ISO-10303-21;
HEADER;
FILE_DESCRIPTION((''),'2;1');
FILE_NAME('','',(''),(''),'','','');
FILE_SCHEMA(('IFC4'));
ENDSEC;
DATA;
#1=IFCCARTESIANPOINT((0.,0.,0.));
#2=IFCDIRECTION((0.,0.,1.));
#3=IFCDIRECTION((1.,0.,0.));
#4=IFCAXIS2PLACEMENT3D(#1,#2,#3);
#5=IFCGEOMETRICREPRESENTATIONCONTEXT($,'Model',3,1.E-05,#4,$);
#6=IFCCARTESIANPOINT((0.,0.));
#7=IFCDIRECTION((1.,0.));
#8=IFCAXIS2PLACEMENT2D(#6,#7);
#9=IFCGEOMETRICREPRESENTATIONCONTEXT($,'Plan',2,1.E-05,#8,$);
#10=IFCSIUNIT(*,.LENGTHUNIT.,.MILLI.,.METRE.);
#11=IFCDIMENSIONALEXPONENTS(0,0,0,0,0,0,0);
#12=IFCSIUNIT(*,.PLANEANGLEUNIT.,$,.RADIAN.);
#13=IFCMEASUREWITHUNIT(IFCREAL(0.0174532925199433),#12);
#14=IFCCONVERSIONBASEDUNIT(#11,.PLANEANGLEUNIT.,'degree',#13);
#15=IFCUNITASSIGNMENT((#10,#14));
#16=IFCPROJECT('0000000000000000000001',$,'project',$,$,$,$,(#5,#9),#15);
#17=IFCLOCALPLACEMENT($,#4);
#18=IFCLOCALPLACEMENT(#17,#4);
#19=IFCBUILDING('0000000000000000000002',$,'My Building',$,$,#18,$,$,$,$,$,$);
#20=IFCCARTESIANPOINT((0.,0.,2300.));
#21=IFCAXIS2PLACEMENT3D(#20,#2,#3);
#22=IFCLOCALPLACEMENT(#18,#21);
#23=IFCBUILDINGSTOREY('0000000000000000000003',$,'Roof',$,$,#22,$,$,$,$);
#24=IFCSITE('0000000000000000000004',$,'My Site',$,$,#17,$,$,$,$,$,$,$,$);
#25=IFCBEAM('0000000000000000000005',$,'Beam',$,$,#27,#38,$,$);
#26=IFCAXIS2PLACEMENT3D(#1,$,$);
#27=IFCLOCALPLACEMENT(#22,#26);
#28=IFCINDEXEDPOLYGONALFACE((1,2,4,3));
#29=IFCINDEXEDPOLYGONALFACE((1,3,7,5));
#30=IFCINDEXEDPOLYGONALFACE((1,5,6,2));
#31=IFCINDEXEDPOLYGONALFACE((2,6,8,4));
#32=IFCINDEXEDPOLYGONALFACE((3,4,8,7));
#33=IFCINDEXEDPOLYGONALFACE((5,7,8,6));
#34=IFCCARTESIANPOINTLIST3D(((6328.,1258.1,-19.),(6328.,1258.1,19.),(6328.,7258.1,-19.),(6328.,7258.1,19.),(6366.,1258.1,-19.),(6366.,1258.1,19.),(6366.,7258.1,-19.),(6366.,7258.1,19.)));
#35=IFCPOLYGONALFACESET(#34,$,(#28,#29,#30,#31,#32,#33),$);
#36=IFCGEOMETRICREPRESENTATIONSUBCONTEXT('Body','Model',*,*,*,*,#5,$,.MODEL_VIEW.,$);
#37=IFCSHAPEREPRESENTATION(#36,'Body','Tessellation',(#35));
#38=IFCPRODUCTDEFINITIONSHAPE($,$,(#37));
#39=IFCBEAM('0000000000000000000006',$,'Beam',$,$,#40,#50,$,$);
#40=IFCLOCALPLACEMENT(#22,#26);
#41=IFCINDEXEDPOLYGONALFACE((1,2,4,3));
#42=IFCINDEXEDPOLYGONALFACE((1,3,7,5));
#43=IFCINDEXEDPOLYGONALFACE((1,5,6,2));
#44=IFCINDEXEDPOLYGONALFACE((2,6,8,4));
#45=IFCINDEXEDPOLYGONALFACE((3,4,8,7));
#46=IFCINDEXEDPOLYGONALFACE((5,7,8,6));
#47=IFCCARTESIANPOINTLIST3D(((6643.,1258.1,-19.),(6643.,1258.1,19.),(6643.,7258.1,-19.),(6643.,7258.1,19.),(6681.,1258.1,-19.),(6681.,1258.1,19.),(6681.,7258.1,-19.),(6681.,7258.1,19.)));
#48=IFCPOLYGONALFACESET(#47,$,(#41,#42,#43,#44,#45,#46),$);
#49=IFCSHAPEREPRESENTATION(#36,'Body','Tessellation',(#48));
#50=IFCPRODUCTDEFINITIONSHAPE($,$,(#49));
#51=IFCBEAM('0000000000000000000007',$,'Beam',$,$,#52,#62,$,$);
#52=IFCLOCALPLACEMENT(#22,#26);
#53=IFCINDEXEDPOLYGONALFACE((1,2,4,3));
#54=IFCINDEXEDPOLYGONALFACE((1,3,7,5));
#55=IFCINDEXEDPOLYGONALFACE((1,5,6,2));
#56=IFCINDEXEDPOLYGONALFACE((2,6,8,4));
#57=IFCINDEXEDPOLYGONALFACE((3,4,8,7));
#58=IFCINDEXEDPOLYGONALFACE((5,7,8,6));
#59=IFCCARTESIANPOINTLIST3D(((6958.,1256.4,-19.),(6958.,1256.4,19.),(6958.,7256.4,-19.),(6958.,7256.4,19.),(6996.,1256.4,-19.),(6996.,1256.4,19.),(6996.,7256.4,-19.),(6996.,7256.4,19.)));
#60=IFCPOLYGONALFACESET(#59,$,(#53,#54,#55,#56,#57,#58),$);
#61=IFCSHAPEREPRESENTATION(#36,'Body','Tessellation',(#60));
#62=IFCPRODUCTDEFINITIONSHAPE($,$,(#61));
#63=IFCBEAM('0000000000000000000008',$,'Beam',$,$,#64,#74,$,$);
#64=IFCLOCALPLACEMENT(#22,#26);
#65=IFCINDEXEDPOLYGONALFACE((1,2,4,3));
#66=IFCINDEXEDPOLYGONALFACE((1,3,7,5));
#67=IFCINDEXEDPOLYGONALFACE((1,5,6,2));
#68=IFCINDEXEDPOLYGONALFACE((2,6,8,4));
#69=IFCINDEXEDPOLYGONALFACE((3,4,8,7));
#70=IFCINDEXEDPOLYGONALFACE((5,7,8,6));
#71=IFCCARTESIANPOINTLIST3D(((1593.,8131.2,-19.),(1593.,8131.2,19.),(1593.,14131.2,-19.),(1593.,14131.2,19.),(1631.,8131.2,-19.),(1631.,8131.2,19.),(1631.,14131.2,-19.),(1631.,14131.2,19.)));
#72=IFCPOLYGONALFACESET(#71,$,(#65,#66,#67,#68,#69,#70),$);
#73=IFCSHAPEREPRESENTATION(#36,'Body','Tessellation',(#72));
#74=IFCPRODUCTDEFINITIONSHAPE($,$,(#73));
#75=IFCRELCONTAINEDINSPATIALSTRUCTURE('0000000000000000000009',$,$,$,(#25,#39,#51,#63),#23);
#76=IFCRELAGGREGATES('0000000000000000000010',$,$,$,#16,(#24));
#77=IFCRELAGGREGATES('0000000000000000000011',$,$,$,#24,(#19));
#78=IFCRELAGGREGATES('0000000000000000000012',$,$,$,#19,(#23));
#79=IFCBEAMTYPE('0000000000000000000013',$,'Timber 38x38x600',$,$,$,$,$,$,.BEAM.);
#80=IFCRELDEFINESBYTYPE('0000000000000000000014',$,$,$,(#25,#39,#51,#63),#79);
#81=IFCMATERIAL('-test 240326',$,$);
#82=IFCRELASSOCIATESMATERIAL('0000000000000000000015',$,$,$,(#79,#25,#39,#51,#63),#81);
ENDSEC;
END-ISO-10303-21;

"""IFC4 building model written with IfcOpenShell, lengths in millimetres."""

from ifc_helpers import new_model, entity, si_unit, converted_unit, frame, origin_with_axes, origin_2d_with_axis, place, context, subcontext, project, spatial, rectangle, extrude, material, material_profile, profile_set, profile_usage, type_object, element, save


model = new_model("IFC4")

# Units and contexts
model_context = context("Model", 3, precision=1e-05, world=origin_with_axes())
plan_context = context("Plan", 2, precision=1e-05, world=origin_2d_with_axis())
body_context = subcontext(model_context, "Body", "Model", "MODEL_VIEW")
ifc_project = project(units=[si_unit("LENGTHUNIT", "METRE", prefix="MILLI"), converted_unit("PLANEANGLEUNIT", "degree", entity("IfcReal", 0.0174532925199433), si_unit("PLANEANGLEUNIT", "RADIAN"), dimensions=[0, 0, 0, 0, 0, 0, 0])], contexts=[model_context, plan_context])

# Site, building, storey
site_placement = place(None, origin_with_axes())
site = spatial("IfcSite", under=ifc_project, at=site_placement, Name="My Site")
building_placement = place(site_placement, origin_with_axes())
building = spatial("IfcBuilding", under=site, at=building_placement, Name="My Building")
storey_placement = place(building_placement, frame((0.0, 0.0, 2300.0), z_axis=(0.0, 0.0, 1.0), x_axis=(1.0, 0.0, 0.0)))
storey = spatial("IfcBuildingStorey", under=building, at=storey_placement, Name="Roof")

# Beams
ifc_material = material(Name="-test 240326")
ifc_material_profile = material_profile(ifc_material, rectangle(XDim=38.0, YDim=38.0))
ifc_profile_set = profile_set([ifc_material_profile])
beam_type_1 = type_object("IfcBeamType", Name="Timber 38x38x600", PredefinedType="BEAM", material=ifc_profile_set)
ifc_profile_usage_1 = profile_usage(ifc_profile_set, cardinal=5)
beam_1_placement = place(storey_placement, frame((6347.0, 1258.1, 0.0), z_axis=(0.0, 1.0, 0.0), x_axis=(-1.0, 0.0, 0.0)))
element("IfcBeam", 1, at=beam_1_placement, inside=storey, type_object=beam_type_1, material=ifc_profile_usage_1, Name="Beam", context=body_context, shape_type="SweptSolid", body=[
    extrude(rectangle(XDim=38.0, YDim=38.0), origin_with_axes(), (0.0, 0.0, 1.0), 6000.0),
])
ifc_profile_usage_2 = profile_usage(ifc_profile_set, cardinal=5)
beam_2_placement = place(storey_placement, frame((6662.0, 1258.1, 0.0), z_axis=(0.0, 1.0, 0.0), x_axis=(-1.0, 0.0, 0.0)))
element("IfcBeam", 2, at=beam_2_placement, inside=storey, type_object=beam_type_1, material=ifc_profile_usage_2, Name="Beam", context=body_context, shape_type="SweptSolid", body=[
    extrude(rectangle(XDim=38.0, YDim=38.0), origin_with_axes(), (0.0, 0.0, 1.0), 6000.0),
])
ifc_profile_usage_3 = profile_usage(ifc_profile_set, cardinal=5)
beam_3_placement = place(storey_placement, frame((6977.0, 1256.4, 0.0), z_axis=(0.0, 1.0, 0.0), x_axis=(-1.0, 0.0, 0.0)))
element("IfcBeam", 3, at=beam_3_placement, inside=storey, type_object=beam_type_1, material=ifc_profile_usage_3, Name="Beam", context=body_context, shape_type="SweptSolid", body=[
    extrude(rectangle(XDim=38.0, YDim=38.0), origin_with_axes(), (0.0, 0.0, 1.0), 6000.0),
])
ifc_profile_usage_4 = profile_usage(ifc_profile_set, cardinal=5)
beam_4_placement = place(storey_placement, frame((1612.0, 8131.2, 0.0), z_axis=(0.0, 1.0, 0.0), x_axis=(-1.0, 0.0, 0.0)))
element("IfcBeam", 4, at=beam_4_placement, inside=storey, type_object=beam_type_1, material=ifc_profile_usage_4, Name="Beam", context=body_context, shape_type="SweptSolid", body=[
    extrude(rectangle(XDim=38.0, YDim=38.0), origin_with_axes(), (0.0, 0.0, 1.0), 6000.0),
])

save(model, "model.ifc")
